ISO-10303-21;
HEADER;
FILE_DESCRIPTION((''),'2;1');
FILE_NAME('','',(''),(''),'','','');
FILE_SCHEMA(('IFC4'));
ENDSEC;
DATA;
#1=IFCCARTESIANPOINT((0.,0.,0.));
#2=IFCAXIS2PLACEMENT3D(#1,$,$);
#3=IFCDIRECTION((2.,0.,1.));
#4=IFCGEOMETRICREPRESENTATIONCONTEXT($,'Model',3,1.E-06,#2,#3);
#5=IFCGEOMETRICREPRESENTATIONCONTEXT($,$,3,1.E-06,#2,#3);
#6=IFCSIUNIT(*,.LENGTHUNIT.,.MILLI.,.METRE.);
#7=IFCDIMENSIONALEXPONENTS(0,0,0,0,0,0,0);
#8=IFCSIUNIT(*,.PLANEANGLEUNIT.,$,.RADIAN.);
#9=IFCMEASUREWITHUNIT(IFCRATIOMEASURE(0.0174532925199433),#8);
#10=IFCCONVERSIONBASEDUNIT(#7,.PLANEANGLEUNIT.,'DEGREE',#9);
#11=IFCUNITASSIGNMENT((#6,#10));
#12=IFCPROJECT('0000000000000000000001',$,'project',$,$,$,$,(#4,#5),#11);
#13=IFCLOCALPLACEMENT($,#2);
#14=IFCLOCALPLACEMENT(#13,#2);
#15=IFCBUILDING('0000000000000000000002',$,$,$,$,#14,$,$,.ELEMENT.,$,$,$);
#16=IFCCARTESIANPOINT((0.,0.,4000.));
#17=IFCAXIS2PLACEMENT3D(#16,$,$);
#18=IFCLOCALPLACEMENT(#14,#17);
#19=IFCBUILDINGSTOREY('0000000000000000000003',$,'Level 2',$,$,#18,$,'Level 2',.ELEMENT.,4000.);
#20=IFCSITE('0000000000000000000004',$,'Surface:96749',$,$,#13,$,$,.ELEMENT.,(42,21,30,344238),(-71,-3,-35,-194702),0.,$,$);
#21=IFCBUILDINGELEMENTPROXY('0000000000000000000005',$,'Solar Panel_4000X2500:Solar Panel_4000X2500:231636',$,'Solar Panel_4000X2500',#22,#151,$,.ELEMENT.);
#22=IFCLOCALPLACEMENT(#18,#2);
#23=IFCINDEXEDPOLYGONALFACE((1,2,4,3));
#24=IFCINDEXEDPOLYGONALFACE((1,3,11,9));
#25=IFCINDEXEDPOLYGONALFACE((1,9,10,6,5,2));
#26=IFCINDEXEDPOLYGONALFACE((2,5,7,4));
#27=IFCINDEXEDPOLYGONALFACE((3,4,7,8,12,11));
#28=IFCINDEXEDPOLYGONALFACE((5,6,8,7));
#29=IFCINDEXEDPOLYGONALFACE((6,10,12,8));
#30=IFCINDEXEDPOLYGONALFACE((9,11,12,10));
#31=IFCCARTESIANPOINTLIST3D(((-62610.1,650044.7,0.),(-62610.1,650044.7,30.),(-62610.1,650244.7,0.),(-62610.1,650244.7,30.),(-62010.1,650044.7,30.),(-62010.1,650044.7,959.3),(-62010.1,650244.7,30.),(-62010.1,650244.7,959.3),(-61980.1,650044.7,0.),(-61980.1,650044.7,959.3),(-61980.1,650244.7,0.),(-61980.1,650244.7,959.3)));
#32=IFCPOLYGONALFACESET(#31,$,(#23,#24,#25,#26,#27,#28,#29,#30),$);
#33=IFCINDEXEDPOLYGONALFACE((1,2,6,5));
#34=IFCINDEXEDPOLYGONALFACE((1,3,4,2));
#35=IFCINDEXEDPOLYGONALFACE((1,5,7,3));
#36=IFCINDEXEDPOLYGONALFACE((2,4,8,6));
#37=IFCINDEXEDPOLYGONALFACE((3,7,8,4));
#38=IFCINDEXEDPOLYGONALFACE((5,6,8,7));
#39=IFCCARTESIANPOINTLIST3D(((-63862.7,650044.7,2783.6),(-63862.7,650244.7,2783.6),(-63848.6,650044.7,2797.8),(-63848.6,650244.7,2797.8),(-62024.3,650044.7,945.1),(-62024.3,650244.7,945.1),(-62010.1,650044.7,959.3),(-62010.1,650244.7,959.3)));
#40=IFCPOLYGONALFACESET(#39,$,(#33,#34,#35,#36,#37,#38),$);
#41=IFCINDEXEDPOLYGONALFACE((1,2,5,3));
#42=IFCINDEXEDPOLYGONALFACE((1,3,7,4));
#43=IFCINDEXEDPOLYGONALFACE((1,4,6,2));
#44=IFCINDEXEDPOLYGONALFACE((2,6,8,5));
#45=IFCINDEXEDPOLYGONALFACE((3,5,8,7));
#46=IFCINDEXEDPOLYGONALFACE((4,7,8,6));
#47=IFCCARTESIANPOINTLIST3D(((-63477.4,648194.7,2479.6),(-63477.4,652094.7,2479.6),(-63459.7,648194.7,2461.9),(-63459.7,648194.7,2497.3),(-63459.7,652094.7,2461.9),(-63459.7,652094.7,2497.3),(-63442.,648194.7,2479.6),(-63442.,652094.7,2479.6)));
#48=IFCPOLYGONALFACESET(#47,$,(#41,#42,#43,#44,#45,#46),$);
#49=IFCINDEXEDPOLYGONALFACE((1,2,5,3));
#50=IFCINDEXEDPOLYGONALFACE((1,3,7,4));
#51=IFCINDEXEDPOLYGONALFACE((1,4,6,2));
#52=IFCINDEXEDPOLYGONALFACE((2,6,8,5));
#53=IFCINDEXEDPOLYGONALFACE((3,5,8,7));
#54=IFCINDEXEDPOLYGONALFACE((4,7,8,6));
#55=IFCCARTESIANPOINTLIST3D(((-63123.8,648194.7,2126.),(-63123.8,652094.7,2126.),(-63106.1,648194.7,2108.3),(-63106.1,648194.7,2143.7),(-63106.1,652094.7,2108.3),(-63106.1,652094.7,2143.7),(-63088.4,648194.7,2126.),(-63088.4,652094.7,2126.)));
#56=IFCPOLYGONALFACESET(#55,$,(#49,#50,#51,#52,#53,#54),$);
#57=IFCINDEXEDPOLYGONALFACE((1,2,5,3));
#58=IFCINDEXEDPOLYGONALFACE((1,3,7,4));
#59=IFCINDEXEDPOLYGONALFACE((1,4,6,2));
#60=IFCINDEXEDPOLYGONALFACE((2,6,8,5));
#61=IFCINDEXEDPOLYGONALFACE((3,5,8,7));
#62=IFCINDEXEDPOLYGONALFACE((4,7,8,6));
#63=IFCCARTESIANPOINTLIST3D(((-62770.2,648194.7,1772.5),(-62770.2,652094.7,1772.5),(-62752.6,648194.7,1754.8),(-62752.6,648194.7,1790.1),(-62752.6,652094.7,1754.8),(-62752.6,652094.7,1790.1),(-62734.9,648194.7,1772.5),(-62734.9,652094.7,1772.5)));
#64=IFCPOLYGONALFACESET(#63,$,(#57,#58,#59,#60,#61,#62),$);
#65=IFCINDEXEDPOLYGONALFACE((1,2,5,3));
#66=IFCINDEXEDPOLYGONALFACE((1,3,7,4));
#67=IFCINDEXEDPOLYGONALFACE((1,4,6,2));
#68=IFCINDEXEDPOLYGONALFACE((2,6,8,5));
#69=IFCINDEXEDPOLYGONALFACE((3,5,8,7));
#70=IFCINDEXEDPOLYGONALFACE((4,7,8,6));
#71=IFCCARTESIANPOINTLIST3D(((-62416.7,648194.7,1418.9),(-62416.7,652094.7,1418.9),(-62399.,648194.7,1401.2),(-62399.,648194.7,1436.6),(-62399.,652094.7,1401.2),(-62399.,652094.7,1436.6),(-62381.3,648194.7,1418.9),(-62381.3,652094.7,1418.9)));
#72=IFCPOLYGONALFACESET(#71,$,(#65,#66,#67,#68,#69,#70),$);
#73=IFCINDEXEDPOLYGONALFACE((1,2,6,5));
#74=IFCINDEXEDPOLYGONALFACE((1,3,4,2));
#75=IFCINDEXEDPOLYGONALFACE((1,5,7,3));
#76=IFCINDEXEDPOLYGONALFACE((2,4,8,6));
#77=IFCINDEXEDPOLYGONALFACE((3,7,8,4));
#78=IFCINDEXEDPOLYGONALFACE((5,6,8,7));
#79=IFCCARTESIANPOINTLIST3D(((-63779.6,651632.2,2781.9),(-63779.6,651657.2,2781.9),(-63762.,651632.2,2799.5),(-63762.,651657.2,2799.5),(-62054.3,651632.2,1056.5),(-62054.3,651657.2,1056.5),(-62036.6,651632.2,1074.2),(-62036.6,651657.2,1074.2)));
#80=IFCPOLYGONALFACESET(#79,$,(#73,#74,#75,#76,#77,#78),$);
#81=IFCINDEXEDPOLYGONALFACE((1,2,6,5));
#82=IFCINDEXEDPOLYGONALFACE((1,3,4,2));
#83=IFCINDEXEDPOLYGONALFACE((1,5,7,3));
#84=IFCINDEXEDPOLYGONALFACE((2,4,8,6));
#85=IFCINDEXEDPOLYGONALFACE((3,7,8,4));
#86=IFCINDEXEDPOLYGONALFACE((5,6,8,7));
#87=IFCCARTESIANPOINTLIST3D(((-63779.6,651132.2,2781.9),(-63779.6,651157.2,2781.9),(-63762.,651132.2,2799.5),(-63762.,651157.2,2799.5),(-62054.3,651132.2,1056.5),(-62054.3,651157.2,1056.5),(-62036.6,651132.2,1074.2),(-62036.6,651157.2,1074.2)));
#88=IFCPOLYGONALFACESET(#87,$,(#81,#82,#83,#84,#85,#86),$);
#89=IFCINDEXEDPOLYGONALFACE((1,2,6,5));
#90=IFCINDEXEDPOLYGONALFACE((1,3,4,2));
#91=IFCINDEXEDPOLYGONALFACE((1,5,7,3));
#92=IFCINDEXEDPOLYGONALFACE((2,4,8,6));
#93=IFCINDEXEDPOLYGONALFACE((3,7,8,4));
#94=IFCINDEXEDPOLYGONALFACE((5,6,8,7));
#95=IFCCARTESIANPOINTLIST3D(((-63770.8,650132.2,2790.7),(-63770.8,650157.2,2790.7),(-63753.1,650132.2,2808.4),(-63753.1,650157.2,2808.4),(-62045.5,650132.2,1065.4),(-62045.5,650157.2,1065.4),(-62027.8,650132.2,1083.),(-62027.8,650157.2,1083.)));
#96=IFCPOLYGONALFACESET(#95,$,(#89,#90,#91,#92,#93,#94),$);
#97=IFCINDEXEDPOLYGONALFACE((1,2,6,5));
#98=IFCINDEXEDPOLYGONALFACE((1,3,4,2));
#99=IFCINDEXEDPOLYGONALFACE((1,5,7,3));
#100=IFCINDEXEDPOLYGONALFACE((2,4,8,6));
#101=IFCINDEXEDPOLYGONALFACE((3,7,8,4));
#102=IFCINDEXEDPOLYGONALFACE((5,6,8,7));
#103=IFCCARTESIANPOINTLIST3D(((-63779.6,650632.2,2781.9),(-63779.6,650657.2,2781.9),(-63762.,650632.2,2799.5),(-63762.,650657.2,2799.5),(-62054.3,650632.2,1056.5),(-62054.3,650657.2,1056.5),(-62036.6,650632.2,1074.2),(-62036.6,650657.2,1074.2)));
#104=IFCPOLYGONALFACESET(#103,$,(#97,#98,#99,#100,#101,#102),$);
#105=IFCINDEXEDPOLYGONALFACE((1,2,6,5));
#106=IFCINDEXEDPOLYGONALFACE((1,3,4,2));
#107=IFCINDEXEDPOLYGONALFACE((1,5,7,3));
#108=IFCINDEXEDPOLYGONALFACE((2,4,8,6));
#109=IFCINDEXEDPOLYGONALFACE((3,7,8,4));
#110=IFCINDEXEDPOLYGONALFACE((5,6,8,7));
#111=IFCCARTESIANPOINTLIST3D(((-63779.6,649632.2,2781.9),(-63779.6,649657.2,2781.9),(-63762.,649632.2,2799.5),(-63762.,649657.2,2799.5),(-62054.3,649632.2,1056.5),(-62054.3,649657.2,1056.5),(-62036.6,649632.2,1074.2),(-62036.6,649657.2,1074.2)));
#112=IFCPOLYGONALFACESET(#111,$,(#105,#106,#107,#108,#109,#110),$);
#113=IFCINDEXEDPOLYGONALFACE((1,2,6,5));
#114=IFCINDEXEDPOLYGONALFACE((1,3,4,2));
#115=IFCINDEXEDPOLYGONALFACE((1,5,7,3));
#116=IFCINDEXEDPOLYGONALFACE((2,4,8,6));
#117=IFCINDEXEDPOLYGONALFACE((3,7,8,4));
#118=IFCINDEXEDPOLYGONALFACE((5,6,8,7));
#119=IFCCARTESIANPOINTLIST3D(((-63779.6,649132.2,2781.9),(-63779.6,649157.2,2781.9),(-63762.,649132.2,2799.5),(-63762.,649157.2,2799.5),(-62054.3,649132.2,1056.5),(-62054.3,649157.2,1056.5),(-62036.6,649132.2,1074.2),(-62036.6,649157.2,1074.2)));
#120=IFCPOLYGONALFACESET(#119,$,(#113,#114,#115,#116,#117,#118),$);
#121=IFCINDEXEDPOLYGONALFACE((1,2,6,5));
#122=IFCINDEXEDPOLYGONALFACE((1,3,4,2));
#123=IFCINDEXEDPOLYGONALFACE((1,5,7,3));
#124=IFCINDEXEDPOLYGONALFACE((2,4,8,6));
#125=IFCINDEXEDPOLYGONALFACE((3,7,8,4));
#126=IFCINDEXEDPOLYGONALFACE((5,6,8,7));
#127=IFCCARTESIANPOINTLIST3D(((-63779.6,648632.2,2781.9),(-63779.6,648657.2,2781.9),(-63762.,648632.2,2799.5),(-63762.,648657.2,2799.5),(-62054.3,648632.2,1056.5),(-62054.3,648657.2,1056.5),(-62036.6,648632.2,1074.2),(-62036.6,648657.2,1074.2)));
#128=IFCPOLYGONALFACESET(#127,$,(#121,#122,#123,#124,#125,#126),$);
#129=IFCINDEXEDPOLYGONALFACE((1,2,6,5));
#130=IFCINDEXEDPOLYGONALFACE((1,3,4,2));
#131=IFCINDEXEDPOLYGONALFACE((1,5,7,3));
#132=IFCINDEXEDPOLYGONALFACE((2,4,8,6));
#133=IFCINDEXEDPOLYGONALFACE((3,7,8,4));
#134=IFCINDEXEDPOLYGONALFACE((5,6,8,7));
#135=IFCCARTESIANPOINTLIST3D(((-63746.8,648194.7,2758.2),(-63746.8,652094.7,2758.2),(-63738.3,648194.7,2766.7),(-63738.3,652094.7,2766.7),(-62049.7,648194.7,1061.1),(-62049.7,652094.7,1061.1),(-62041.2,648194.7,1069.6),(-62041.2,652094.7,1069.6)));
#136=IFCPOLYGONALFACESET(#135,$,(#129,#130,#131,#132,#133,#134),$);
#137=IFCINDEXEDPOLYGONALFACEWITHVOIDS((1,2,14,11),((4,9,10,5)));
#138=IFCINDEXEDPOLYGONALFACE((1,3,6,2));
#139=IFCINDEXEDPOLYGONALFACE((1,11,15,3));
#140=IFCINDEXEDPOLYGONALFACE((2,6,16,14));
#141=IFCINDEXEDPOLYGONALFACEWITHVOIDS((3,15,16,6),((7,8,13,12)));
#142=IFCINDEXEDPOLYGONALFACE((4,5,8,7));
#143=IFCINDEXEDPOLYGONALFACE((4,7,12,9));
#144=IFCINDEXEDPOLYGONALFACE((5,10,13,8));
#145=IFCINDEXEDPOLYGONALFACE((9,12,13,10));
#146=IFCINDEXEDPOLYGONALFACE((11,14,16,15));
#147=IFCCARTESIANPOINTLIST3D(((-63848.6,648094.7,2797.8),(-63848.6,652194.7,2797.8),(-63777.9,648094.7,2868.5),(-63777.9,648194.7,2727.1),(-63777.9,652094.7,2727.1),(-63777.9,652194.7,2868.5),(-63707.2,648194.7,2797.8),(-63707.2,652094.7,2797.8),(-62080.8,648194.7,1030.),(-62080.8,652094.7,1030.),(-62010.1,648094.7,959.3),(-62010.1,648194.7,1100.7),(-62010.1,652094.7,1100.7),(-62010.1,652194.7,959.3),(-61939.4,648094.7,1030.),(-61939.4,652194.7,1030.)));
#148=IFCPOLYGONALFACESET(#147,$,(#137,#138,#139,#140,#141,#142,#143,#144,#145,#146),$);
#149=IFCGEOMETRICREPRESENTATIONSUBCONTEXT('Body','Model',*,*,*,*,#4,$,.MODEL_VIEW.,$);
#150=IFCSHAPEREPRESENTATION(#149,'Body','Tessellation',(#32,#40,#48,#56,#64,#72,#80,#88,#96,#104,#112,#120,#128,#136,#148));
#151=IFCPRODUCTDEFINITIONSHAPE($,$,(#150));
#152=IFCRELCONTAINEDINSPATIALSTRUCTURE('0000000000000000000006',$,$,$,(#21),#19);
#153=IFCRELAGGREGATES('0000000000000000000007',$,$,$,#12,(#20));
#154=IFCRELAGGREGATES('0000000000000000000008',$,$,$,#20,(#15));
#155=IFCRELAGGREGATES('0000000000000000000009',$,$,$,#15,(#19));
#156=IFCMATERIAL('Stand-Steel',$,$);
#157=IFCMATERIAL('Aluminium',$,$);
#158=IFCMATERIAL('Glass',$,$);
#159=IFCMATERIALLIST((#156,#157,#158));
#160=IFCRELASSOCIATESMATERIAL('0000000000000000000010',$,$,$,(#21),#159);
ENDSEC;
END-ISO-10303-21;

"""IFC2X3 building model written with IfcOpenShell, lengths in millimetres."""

from ifc_helpers import new_model, entity, si_unit, converted_unit, direction, frame, frame_2d, origin, origin_2d_with_axis, place, context, subcontext, project, spatial, polyline, rectangle, outline, extrude, source, transform, mapped, material, material_list, element, save


model = new_model("IFC2X3")

# Units and contexts
model_context = context("Model", 3, precision=1e-06, world=origin(), true_north=direction((2.0, 0.0, 1.0)))
context_of_model = context(None, 3, precision=1e-06, world=origin(), true_north=direction((2.0, 0.0, 1.0)))
body_context = subcontext(model_context, "Body", "Model", "MODEL_VIEW")
ifc_project = project(units=[si_unit("LENGTHUNIT", "METRE", prefix="MILLI"), converted_unit("PLANEANGLEUNIT", "DEGREE", entity("IfcRatioMeasure", 0.0174532925199433), si_unit("PLANEANGLEUNIT", "RADIAN"), dimensions=[0, 0, 0, 0, 0, 0, 0])], contexts=[model_context, context_of_model])

# Site, building, storey
site_placement = place(None, origin())
site = spatial("IfcSite", under=ifc_project, at=site_placement, Name="Surface:96749", CompositionType="ELEMENT", RefLatitude=(42, 21, 30, 344238), RefLongitude=(-71, -3, -35, -194702), RefElevation=0.0)
building_placement = place(site_placement, origin())
building = spatial("IfcBuilding", under=site, at=building_placement, CompositionType="ELEMENT")
storey_placement = place(building_placement, frame((0.0, 0.0, 4000.0)))
storey = spatial("IfcBuildingStorey", under=building, at=storey_placement, Name="Level 2", LongName="Level 2", CompositionType="ELEMENT", Elevation=4000.0)

# Building element proxy
ifc_material_1 = material(Name="Stand-Steel")
ifc_material_2 = material(Name="Aluminium")
ifc_material_3 = material(Name="Glass")
shared_shape = source(origin(), body_context, "Body", "SweptSolid", [
    extrude(outline(polyline([(-629.5, -220.0), (329.8, -220.0), (329.8, 410.0), (299.8, 410.0), (299.8, -190.0), (-629.5, -190.0), (-629.5, -220.0)])), frame((-190.0, -100.0, 299.8), z_axis=(0.0, 1.0, 0.0), x_axis=(0.0, 0.0, -1.0)), (0.0, 0.0, 1.0), 200.0),
    extrude(rectangle(XDim=20.0, YDim=200.0, at=frame_2d((0.0, 0.0), x_axis=(0.0, 1.0))), frame((-7.1, 0.0, 922.2), z_axis=(-0.707107, 0.0, 0.707107), x_axis=(0.0, 1.0, 0.0)), (0.0, 0.0, 1.0), 2600.0),
    extrude(rectangle(XDim=25.0, YDim=25.0, at=frame_2d((0.0, 0.0), x_axis=(1.0, 0.0))), frame((-1449.6, -1950.0, 2449.6), z_axis=(0.0, 1.0, 0.0), x_axis=(-0.707107, 0.0, -0.707107)), (0.0, 0.0, 1.0), 3900.0),
    extrude(rectangle(XDim=25.0, YDim=25.0, at=origin_2d_with_axis()), frame((-1096.0, -1950.0, 2096.0), z_axis=(0.0, 1.0, 0.0), x_axis=(-0.707107, 0.0, -0.707107)), (0.0, 0.0, 1.0), 3900.0),
    extrude(rectangle(XDim=25.0, YDim=25.0, at=origin_2d_with_axis()), frame((-742.5, -1950.0, 1742.5), z_axis=(0.0, 1.0, 0.0), x_axis=(-0.707107, 0.0, -0.707107)), (0.0, 0.0, 1.0), 3900.0),
    extrude(rectangle(XDim=25.0, YDim=25.0, at=frame_2d((0.0, 0.0), x_axis=(1.0, 0.0))), frame((-388.9, -1950.0, 1388.9), z_axis=(0.0, 1.0, 0.0), x_axis=(-0.707107, 0.0, -0.707107)), (0.0, 0.0, 1.0), 3900.0),
    extrude(rectangle(XDim=25.0, YDim=25.0, at=frame_2d((0.0, 0.0), x_axis=(0.0, 1.0))), frame((-35.4, 1500.0, 1035.4), z_axis=(-0.707107, 0.0, 0.707107), x_axis=(0.0, 1.0, 0.0)), (0.0, 0.0, 1.0), 2440.0),
    extrude(rectangle(XDim=25.0, YDim=25.0, at=frame_2d((0.0, 0.0), x_axis=(0.0, 1.0))), frame((-35.4, 1000.0, 1035.4), z_axis=(-0.707107, 0.0, 0.707107), x_axis=(0.0, 1.0, 0.0)), (0.0, 0.0, 1.0), 2440.0),
    extrude(rectangle(XDim=25.0, YDim=25.0, at=frame_2d((0.0, 0.0), x_axis=(0.0, 1.0))), frame((-26.5, 0.0, 1044.2), z_axis=(-0.707107, 0.0, 0.707107), x_axis=(0.0, -1.0, 0.0)), (0.0, 0.0, 1.0), 2440.0),
    extrude(rectangle(XDim=25.0, YDim=25.0, at=frame_2d((0.0, 0.0), x_axis=(0.0, 1.0))), frame((-35.4, 500.0, 1035.4), z_axis=(-0.707107, 0.0, 0.707107), x_axis=(0.0, 1.0, 0.0)), (0.0, 0.0, 1.0), 2440.0),
    extrude(rectangle(XDim=25.0, YDim=25.0, at=frame_2d((0.0, 0.0), x_axis=(0.0, 1.0))), frame((-35.4, -500.0, 1035.4), z_axis=(-0.707107, 0.0, 0.707107), x_axis=(0.0, 1.0, 0.0)), (0.0, 0.0, 1.0), 2440.0),
    extrude(rectangle(XDim=25.0, YDim=25.0, at=frame_2d((0.0, 0.0), x_axis=(0.0, 1.0))), frame((-35.4, -1000.0, 1035.4), z_axis=(-0.707107, 0.0, 0.707107), x_axis=(0.0, 1.0, 0.0)), (0.0, 0.0, 1.0), 2440.0),
    extrude(rectangle(XDim=25.0, YDim=25.0, at=frame_2d((0.0, 0.0), x_axis=(0.0, 1.0))), frame((-35.4, -1500.0, 1035.4), z_axis=(-0.707107, 0.0, 0.707107), x_axis=(0.0, 1.0, 0.0)), (0.0, 0.0, 1.0), 2440.0),
    extrude(rectangle(XDim=2400.0, YDim=12.0, at=frame_2d((0.0, 0.0), x_axis=(1.0, 0.0))), frame((-883.9, -1950.0, 1883.9), z_axis=(0.0, 1.0, 0.0), x_axis=(0.707107, 0.0, -0.707107)), (0.0, 0.0, 1.0), 3900.0),
    extrude(outline(polyline([(-2050.0, -1300.0), (2050.0, -1300.0), (2050.0, 1300.0), (-2050.0, 1300.0), (-2050.0, -1300.0)]), holes=[polyline([(1950.0, -1200.0), (-1950.0, -1200.0), (-1950.0, 1200.0), (1950.0, 1200.0), (1950.0, -1200.0)])]), frame((-919.2, 0.0, 1848.5), z_axis=(0.707107, 0.0, 0.707107), x_axis=(0.0, 1.0, 0.0)), (0.0, 0.0, 1.0), 100.0),
])
ifc_material_list_1 = material_list([ifc_material_1, ifc_material_2, ifc_material_3])
proxy_1_placement = place(storey_placement, frame((-62010.1, 650144.7, 30.0)))
element("IfcBuildingElementProxy", 1, at=proxy_1_placement, inside=storey, material=ifc_material_list_1, Name="Solar Panel_4000X2500:Solar Panel_4000X2500:231636", ObjectType="Solar Panel_4000X2500", CompositionType="ELEMENT", context=body_context, shape_type="MappedRepresentation", body=[
    mapped(shared_shape, transform((0.0, 0.0, 0.0), scale=1.0)),
])

save(model, "model.ifc")
